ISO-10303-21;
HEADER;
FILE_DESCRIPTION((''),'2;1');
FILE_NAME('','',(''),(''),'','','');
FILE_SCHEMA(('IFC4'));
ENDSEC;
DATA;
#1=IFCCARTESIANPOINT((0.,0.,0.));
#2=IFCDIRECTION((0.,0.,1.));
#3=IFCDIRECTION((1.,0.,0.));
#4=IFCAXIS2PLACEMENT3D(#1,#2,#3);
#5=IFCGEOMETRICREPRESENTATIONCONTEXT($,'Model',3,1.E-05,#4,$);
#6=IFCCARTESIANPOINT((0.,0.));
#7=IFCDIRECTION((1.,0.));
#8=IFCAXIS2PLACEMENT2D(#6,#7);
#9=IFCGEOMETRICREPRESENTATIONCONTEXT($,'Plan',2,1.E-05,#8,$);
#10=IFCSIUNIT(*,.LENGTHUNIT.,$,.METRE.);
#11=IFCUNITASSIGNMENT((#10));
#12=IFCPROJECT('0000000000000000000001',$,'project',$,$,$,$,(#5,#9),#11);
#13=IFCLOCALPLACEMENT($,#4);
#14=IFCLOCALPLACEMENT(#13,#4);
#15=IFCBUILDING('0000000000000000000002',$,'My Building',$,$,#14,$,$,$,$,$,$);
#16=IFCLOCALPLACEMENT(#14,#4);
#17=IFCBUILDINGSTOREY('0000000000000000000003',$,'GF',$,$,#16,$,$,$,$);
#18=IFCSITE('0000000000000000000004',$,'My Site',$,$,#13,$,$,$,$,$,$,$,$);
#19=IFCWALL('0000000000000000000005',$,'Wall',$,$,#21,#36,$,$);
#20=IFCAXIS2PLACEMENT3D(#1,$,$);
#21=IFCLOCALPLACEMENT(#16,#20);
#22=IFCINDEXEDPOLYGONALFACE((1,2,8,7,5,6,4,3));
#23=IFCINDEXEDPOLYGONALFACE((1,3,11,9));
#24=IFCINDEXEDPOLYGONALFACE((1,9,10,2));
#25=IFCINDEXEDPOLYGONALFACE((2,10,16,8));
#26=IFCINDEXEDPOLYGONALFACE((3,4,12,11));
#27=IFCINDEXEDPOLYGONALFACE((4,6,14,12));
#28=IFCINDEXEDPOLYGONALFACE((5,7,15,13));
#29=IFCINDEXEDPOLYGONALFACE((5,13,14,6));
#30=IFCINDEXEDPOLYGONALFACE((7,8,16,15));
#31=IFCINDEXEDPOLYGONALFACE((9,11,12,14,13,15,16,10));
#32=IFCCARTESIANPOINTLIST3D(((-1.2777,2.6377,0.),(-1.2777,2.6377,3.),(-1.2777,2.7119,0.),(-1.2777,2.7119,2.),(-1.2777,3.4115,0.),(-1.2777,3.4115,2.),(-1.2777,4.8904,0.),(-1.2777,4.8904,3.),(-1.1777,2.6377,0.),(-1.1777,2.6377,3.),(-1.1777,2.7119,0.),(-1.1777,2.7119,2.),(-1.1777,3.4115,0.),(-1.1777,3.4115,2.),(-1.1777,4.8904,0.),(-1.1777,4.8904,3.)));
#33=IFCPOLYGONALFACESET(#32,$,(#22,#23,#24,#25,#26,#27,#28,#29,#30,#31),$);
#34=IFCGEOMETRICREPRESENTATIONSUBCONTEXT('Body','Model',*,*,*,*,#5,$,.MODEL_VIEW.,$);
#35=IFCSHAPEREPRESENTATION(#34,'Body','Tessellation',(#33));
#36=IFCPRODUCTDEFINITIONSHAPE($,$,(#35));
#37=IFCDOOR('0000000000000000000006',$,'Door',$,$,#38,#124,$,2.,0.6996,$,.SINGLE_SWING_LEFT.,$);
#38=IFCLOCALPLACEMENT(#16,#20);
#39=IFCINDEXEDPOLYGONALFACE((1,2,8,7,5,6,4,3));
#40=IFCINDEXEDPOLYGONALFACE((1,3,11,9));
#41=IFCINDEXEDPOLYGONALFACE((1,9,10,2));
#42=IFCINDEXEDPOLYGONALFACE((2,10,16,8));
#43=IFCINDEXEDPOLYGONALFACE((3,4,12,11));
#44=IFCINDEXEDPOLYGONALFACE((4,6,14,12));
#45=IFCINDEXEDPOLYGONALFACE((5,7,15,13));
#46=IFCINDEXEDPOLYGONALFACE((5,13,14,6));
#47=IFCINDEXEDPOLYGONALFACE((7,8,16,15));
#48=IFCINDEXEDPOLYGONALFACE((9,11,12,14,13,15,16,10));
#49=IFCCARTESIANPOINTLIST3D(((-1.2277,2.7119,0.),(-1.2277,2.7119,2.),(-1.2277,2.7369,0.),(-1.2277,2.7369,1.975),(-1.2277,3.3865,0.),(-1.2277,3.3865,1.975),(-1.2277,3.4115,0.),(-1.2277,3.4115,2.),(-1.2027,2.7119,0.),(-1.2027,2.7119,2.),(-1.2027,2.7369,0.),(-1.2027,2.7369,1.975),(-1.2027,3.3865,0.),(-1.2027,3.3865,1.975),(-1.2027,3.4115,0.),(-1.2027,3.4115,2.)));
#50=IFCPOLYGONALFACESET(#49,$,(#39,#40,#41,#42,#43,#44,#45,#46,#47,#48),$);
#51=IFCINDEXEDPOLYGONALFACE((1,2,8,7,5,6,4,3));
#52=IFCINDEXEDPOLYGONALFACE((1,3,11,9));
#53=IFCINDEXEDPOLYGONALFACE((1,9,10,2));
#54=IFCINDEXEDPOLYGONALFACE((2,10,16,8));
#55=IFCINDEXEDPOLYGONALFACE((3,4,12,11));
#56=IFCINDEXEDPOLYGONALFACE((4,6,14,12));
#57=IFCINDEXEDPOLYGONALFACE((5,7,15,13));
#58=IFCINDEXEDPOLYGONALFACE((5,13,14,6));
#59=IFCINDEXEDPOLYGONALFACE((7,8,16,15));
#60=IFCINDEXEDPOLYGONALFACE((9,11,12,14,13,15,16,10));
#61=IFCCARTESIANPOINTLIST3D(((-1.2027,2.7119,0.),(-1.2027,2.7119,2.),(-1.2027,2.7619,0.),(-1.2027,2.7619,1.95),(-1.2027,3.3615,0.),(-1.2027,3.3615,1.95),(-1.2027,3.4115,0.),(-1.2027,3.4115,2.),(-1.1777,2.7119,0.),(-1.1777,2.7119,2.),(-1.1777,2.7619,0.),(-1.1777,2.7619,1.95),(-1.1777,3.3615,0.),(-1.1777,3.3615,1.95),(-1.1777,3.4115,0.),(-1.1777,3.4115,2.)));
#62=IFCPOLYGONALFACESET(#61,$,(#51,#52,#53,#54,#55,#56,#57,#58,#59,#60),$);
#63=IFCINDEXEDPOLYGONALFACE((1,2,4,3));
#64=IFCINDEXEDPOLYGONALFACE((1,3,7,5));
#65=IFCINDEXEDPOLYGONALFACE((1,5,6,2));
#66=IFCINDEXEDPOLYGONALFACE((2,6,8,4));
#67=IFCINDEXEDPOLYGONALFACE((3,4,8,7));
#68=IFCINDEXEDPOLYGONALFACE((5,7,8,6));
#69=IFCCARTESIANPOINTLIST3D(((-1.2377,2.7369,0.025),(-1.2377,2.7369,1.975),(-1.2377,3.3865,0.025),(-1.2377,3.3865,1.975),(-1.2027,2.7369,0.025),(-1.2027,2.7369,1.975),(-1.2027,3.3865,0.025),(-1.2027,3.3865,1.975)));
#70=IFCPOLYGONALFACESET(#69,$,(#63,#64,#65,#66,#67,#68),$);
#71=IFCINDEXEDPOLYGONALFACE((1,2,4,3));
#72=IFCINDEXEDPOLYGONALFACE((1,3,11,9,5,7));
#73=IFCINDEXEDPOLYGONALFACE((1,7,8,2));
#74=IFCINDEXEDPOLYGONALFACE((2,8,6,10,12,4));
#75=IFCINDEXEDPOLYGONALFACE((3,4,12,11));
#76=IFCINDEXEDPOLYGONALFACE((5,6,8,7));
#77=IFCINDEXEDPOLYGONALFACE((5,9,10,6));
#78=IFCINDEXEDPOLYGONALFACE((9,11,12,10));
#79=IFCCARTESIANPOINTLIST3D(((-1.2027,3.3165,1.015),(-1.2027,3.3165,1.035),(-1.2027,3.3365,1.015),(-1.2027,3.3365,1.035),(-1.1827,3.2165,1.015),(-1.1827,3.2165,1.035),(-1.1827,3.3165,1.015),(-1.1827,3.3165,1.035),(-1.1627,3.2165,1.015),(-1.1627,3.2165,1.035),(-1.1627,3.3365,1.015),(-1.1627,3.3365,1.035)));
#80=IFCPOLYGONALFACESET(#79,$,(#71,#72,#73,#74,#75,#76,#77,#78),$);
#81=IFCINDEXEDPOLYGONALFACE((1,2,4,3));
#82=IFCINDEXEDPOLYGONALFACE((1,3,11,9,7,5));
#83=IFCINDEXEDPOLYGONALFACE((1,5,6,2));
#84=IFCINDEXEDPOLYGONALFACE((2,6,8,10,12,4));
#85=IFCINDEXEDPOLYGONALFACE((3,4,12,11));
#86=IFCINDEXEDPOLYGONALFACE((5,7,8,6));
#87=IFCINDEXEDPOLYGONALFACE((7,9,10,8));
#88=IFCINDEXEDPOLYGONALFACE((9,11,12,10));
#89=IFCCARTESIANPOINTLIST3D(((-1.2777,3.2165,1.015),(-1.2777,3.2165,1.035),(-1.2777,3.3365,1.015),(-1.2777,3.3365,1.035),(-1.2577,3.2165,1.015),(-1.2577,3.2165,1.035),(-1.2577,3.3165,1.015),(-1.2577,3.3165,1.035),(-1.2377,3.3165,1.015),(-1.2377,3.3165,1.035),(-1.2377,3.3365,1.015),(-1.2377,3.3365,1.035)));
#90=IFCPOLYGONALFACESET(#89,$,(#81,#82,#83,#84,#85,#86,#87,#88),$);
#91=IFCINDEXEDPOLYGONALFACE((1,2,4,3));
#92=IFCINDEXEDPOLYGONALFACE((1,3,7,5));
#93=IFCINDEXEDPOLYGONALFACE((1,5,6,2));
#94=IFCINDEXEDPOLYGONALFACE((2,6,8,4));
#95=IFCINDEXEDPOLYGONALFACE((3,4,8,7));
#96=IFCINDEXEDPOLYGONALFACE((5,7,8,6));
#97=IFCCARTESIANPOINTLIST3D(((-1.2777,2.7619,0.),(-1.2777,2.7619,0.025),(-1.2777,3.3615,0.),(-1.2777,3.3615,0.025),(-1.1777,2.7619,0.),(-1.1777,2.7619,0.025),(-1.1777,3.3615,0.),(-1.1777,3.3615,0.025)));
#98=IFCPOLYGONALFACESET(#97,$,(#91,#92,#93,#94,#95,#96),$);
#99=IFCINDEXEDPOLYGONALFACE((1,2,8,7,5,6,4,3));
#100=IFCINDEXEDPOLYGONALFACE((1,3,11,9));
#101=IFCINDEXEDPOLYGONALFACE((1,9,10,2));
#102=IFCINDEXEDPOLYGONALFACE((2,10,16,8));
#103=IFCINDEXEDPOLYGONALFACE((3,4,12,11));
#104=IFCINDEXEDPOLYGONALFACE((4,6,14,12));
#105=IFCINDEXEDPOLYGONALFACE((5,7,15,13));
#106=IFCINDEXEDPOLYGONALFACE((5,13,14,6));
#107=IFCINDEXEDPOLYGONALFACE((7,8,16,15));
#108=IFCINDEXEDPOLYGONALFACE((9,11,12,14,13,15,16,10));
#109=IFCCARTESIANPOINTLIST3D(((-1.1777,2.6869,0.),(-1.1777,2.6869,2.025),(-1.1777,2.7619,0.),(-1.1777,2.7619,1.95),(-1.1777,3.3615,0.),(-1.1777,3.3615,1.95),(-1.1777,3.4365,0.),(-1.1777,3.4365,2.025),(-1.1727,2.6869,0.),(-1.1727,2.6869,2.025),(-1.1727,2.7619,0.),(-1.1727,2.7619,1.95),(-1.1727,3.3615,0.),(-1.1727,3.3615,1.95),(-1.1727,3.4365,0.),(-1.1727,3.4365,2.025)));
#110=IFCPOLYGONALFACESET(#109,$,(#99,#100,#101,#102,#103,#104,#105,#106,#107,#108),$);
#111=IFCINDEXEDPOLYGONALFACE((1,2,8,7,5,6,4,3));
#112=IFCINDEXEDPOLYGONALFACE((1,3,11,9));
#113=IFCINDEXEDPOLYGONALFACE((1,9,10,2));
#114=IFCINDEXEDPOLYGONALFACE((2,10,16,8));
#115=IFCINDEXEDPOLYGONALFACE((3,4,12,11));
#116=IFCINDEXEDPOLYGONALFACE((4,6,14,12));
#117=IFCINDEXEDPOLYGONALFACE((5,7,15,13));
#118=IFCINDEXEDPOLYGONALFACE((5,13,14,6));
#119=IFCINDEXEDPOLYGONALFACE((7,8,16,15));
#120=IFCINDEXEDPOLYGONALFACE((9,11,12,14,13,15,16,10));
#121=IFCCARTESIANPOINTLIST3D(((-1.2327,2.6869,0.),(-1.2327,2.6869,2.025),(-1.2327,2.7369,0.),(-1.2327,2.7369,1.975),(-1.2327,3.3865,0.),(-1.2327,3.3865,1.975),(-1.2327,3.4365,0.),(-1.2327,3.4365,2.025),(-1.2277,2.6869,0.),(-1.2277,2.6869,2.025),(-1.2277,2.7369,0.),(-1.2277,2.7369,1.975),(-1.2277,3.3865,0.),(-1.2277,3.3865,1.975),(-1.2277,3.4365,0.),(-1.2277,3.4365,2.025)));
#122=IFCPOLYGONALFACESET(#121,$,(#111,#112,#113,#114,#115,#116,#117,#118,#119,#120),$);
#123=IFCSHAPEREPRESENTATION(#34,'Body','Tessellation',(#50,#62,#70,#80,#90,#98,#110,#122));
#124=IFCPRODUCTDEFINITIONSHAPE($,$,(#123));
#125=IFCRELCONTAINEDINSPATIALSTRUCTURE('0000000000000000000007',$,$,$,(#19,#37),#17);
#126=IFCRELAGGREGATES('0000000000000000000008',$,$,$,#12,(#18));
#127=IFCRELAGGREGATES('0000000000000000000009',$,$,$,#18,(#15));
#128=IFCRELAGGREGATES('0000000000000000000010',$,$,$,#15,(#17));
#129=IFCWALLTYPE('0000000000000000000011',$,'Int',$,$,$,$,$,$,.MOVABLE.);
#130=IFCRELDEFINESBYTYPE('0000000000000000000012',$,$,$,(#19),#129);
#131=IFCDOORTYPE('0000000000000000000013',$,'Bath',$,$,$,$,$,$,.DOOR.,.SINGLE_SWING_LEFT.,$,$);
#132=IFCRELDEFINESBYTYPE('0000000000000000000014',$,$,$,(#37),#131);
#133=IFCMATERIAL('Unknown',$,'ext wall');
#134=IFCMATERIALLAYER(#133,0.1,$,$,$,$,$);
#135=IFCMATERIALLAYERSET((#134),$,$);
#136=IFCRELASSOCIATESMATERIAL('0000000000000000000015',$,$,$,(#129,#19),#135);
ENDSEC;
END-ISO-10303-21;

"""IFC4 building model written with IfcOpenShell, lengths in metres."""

from ifc_helpers import new_model, entity, si_unit, frame, origin_with_axes, origin_2d_with_axis, place, context, subcontext, project, spatial, line, indexed_curve, outline, extrude, shape, source, transform, mapped, material, layer, layer_set, layer_usage, type_object, type_shapes, element, fill, save


model = new_model("IFC4")

# Units and contexts
model_context = context("Model", 3, precision=1e-05, world=origin_with_axes())
plan_context = context("Plan", 2, precision=1e-05, world=origin_2d_with_axis())
body_context_1 = subcontext(model_context, "Body", "Model", "MODEL_VIEW")
body_context_2 = subcontext(plan_context, "Body", "Plan", "PLAN_VIEW")
ifc_project = project(units=[si_unit("LENGTHUNIT", "METRE")], contexts=[model_context, plan_context])

# Site, building, storey
site_placement = place(None, origin_with_axes())
site = spatial("IfcSite", under=ifc_project, at=site_placement, Name="My Site")
building_placement = place(site_placement, origin_with_axes())
building = spatial("IfcBuilding", under=site, at=building_placement, Name="My Building")
storey_placement = place(building_placement, origin_with_axes())
storey = spatial("IfcBuildingStorey", under=building, at=storey_placement, Name="GF")

# Shared definitions
ifc_material = material(Name="Unknown", Category="ext wall")

# Wall, opening, door
ifc_layer_1 = layer(ifc_material, 0.1)
ifc_layer_set_1 = layer_set([ifc_layer_1])
ifc_layer_usage_1 = layer_usage(ifc_layer_set_1, "AXIS2", "POSITIVE", 0.0)
wall_type_1 = type_object("IfcWallType", Name="Int", PredefinedType="MOVABLE", material=ifc_layer_set_1)
wall_1_placement = place(storey_placement, frame((-1.2777, 4.8904, 0.0), z_axis=(0.0, 0.0, 1.0), x_axis=(0.0, -1.0, 0.0)))
wall_1 = element("IfcWall", 1, at=wall_1_placement, inside=storey, type_object=wall_type_1, material=ifc_layer_usage_1, Name="Wall", context=body_context_1, shape_type="SweptSolid", body=[
    extrude(outline(indexed_curve([(0.0, 0.0), (0.0, 0.1), (2.2527, 0.1), (2.2527, 0.0)], segments=[line(1, 2, 3, 4, 1)])), origin_with_axes(), (0.0, 0.0, 1.0), 3.0),
])
shared_shape_1 = source(origin_with_axes(), body_context_1, "Body", "SweptSolid", [
    extrude(outline(indexed_curve([(0.0, 0.0), (0.6996, 0.0), (0.6996, 2.0), (0.0, 2.0)], segments=[line(1, 2, 3, 4, 1)])), frame((0.0, -0.6, 0.0), z_axis=(0.0, -1.0, 0.0), x_axis=(1.0, 0.0, 0.0)), (0.0, 0.0, -1.0), 1.2),
])
opening_1_placement = place(wall_1_placement, frame((2.1785, 0.1, 0.0), z_axis=(0.0, 0.0, 1.0), x_axis=(-1.0, 0.0, 0.0)))
opening_1 = element("IfcOpeningElement", 2, at=opening_1_placement, cuts=wall_1, PredefinedType="OPENING", context=body_context_1, shape_type="MappedRepresentation", body=[
    mapped(shared_shape_1, transform((0.0, 0.0, 0.0), x_axis=(1.0, 0.0, 0.0), y_axis=(0.0, 1.0, 0.0), z_axis=(0.0, 0.0, 1.0), scale=1.0)),
])
door_type_1 = type_object("IfcDoorType", Name="Bath", OperationType="SINGLE_SWING_LEFT", PredefinedType="DOOR")
shared_shape_2 = source(origin_with_axes(), body_context_1, "Body", "SweptSolid", [
    extrude(outline(indexed_curve([(0.0, 0.0), (0.0, 2.0), (0.6996, 2.0), (0.6996, 0.0), (0.6746, 0.0), (0.6746, 1.975), (0.025, 1.975), (0.025, 0.0)], segments=[line(1, 2, 3, 4, 5, 6, 7, 8, 1)])), frame((0.0, 0.025, 0.0), z_axis=(0.0, -1.0, 0.0), x_axis=(1.0, 0.0, 0.0)), (0.0, 0.0, -1.0), 0.025),
    extrude(outline(indexed_curve([(0.0, 0.0), (0.0, 2.0), (0.6996, 2.0), (0.6996, 0.0), (0.6496, 0.0), (0.6496, 1.95), (0.05, 1.95), (0.05, 0.0)], segments=[line(1, 2, 3, 4, 5, 6, 7, 8, 1)])), frame((0.0, 0.0, 0.0), z_axis=(0.0, -1.0, 0.0), x_axis=(1.0, 0.0, 0.0)), (0.0, 0.0, -1.0), 0.025),
    extrude(outline(indexed_curve([(0.0, 0.0), (0.6496, 0.0), (0.6496, 0.035), (0.0, 0.035)], segments=[line(1, 2, 3, 4, 1)])), frame((0.025, 0.025, 0.025), z_axis=(0.0, 0.0, 1.0), x_axis=(1.0, 0.0, 0.0)), (0.0, 0.0, 1.0), 1.95),
    extrude(outline(indexed_curve([(0.0, 0.0), (0.0, -0.04), (-0.12, -0.04), (-0.12, -0.02), (-0.02, -0.02), (-0.02, 0.0)], segments=[line(1, 2, 3, 4, 5, 6, 1)])), frame((0.6246, 0.025, 1.015), z_axis=(0.0, 0.0, 1.0), x_axis=(1.0, 0.0, 0.0)), (0.0, 0.0, 1.0), 0.02),
    extrude(outline(indexed_curve([(0.0, 0.0), (0.0, 0.04), (-0.12, 0.04), (-0.12, 0.02), (-0.02, 0.02), (-0.02, 0.0)], segments=[line(1, 2, 3, 4, 5, 6, 1)])), frame((0.6246, 0.06, 1.015), z_axis=(0.0, 0.0, 1.0), x_axis=(1.0, 0.0, 0.0)), (0.0, 0.0, 1.0), 0.02),
    extrude(outline(indexed_curve([(0.0, 0.0), (0.5996, 0.0), (0.5996, 0.1), (0.0, 0.1)], segments=[line(1, 2, 3, 4, 1)])), frame((0.05, 0.0, 0.0), z_axis=(0.0, 0.0, 1.0), x_axis=(1.0, 0.0, 0.0)), (0.0, 0.0, 1.0), 0.025),
    extrude(outline(indexed_curve([(0.0, 0.0), (0.0, 2.025), (0.7496, 2.025), (0.7496, 0.0), (0.6746, 0.0), (0.6746, 1.95), (0.075, 1.95), (0.075, 0.0)], segments=[line(1, 2, 3, 4, 5, 6, 7, 8, 1)])), frame((-0.025, -0.005, 0.0), z_axis=(0.0, -1.0, 0.0), x_axis=(1.0, 0.0, 0.0)), (0.0, 0.0, -1.0), 0.005),
    extrude(outline(indexed_curve([(0.0, 0.0), (0.0, 2.025), (0.7496, 2.025), (0.7496, 0.0), (0.6996, 0.0), (0.6996, 1.975), (0.05, 1.975), (0.05, 0.0)], segments=[line(1, 2, 3, 4, 5, 6, 7, 8, 1)])), frame((-0.025, 0.05, 0.0), z_axis=(0.0, -1.0, 0.0), x_axis=(1.0, 0.0, 0.0)), (0.0, 0.0, -1.0), 0.005),
])
shared_shape_3 = source(origin_with_axes(), body_context_2, "Body", "Curve2D", [
    entity("IfcIndexedPolyCurve", entity("IfcCartesianPointList2D", [[0.0, 0.0], [0.0, 0.05], [0.025, 0.05], [0.025, 0.025], [0.05, 0.025], [0.05, 0.0]]), [entity("IfcLineIndex", [1, 2, 3, 4, 5, 6, 1])]),
    entity("IfcIndexedPolyCurve", entity("IfcCartesianPointList2D", [[0.6996, 0.0], [0.6996, 0.05], [0.6746, 0.05], [0.6746, 0.025], [0.6496, 0.025], [0.6496, 0.0]]), [entity("IfcLineIndex", [1, 2, 3, 4, 5, 6, 1])]),
    entity("IfcTrimmedCurve", entity("IfcEllipse", entity("IfcAxis2Placement2D", entity("IfcCartesianPoint", [0.06, 0.05]), entity("IfcDirection", [1.0, 0.0])), 0.6146, 0.6496), [entity("IfcCartesianPoint", [0.6746, 0.05])], [entity("IfcCartesianPoint", [0.06, 0.6996])], True, "CARTESIAN"),
    entity("IfcIndexedPolyCurve", entity("IfcCartesianPointList2D", [[0.025, 0.05], [0.06, 0.05], [0.06, 0.6996], [0.025, 0.6996]]), [entity("IfcLineIndex", [1, 2, 3, 4, 1])]),
])
type_shapes(door_type_1, [shared_shape_2, shared_shape_3])
door_1_placement = place(opening_1_placement, frame((0.0, 0.0, 0.0), z_axis=(0.0, 0.0, 1.0), x_axis=(1.0, 0.0, 0.0)))
door_1 = element("IfcDoor", 3, at=door_1_placement, inside=storey, type_object=door_type_1, Name="Door", OperationType="SINGLE_SWING_LEFT", OverallHeight=2.0, OverallWidth=0.6996, shapes=[
    shape(body_context_1, "Body", "MappedRepresentation", [mapped(shared_shape_2, transform((0.0, 0.0, 0.0), x_axis=(1.0, 0.0, 0.0), y_axis=(0.0, 1.0, 0.0), z_axis=(0.0, 0.0, 1.0), scale=1.0))]),
    shape(body_context_2, "Body", "MappedRepresentation", [mapped(shared_shape_3, transform((0.0, 0.0, 0.0), x_axis=(1.0, 0.0, 0.0), y_axis=(0.0, 1.0, 0.0), z_axis=(0.0, 0.0, 1.0), scale=1.0))]),
])
fill(opening_1, door_1)

save(model, "model.ifc")
